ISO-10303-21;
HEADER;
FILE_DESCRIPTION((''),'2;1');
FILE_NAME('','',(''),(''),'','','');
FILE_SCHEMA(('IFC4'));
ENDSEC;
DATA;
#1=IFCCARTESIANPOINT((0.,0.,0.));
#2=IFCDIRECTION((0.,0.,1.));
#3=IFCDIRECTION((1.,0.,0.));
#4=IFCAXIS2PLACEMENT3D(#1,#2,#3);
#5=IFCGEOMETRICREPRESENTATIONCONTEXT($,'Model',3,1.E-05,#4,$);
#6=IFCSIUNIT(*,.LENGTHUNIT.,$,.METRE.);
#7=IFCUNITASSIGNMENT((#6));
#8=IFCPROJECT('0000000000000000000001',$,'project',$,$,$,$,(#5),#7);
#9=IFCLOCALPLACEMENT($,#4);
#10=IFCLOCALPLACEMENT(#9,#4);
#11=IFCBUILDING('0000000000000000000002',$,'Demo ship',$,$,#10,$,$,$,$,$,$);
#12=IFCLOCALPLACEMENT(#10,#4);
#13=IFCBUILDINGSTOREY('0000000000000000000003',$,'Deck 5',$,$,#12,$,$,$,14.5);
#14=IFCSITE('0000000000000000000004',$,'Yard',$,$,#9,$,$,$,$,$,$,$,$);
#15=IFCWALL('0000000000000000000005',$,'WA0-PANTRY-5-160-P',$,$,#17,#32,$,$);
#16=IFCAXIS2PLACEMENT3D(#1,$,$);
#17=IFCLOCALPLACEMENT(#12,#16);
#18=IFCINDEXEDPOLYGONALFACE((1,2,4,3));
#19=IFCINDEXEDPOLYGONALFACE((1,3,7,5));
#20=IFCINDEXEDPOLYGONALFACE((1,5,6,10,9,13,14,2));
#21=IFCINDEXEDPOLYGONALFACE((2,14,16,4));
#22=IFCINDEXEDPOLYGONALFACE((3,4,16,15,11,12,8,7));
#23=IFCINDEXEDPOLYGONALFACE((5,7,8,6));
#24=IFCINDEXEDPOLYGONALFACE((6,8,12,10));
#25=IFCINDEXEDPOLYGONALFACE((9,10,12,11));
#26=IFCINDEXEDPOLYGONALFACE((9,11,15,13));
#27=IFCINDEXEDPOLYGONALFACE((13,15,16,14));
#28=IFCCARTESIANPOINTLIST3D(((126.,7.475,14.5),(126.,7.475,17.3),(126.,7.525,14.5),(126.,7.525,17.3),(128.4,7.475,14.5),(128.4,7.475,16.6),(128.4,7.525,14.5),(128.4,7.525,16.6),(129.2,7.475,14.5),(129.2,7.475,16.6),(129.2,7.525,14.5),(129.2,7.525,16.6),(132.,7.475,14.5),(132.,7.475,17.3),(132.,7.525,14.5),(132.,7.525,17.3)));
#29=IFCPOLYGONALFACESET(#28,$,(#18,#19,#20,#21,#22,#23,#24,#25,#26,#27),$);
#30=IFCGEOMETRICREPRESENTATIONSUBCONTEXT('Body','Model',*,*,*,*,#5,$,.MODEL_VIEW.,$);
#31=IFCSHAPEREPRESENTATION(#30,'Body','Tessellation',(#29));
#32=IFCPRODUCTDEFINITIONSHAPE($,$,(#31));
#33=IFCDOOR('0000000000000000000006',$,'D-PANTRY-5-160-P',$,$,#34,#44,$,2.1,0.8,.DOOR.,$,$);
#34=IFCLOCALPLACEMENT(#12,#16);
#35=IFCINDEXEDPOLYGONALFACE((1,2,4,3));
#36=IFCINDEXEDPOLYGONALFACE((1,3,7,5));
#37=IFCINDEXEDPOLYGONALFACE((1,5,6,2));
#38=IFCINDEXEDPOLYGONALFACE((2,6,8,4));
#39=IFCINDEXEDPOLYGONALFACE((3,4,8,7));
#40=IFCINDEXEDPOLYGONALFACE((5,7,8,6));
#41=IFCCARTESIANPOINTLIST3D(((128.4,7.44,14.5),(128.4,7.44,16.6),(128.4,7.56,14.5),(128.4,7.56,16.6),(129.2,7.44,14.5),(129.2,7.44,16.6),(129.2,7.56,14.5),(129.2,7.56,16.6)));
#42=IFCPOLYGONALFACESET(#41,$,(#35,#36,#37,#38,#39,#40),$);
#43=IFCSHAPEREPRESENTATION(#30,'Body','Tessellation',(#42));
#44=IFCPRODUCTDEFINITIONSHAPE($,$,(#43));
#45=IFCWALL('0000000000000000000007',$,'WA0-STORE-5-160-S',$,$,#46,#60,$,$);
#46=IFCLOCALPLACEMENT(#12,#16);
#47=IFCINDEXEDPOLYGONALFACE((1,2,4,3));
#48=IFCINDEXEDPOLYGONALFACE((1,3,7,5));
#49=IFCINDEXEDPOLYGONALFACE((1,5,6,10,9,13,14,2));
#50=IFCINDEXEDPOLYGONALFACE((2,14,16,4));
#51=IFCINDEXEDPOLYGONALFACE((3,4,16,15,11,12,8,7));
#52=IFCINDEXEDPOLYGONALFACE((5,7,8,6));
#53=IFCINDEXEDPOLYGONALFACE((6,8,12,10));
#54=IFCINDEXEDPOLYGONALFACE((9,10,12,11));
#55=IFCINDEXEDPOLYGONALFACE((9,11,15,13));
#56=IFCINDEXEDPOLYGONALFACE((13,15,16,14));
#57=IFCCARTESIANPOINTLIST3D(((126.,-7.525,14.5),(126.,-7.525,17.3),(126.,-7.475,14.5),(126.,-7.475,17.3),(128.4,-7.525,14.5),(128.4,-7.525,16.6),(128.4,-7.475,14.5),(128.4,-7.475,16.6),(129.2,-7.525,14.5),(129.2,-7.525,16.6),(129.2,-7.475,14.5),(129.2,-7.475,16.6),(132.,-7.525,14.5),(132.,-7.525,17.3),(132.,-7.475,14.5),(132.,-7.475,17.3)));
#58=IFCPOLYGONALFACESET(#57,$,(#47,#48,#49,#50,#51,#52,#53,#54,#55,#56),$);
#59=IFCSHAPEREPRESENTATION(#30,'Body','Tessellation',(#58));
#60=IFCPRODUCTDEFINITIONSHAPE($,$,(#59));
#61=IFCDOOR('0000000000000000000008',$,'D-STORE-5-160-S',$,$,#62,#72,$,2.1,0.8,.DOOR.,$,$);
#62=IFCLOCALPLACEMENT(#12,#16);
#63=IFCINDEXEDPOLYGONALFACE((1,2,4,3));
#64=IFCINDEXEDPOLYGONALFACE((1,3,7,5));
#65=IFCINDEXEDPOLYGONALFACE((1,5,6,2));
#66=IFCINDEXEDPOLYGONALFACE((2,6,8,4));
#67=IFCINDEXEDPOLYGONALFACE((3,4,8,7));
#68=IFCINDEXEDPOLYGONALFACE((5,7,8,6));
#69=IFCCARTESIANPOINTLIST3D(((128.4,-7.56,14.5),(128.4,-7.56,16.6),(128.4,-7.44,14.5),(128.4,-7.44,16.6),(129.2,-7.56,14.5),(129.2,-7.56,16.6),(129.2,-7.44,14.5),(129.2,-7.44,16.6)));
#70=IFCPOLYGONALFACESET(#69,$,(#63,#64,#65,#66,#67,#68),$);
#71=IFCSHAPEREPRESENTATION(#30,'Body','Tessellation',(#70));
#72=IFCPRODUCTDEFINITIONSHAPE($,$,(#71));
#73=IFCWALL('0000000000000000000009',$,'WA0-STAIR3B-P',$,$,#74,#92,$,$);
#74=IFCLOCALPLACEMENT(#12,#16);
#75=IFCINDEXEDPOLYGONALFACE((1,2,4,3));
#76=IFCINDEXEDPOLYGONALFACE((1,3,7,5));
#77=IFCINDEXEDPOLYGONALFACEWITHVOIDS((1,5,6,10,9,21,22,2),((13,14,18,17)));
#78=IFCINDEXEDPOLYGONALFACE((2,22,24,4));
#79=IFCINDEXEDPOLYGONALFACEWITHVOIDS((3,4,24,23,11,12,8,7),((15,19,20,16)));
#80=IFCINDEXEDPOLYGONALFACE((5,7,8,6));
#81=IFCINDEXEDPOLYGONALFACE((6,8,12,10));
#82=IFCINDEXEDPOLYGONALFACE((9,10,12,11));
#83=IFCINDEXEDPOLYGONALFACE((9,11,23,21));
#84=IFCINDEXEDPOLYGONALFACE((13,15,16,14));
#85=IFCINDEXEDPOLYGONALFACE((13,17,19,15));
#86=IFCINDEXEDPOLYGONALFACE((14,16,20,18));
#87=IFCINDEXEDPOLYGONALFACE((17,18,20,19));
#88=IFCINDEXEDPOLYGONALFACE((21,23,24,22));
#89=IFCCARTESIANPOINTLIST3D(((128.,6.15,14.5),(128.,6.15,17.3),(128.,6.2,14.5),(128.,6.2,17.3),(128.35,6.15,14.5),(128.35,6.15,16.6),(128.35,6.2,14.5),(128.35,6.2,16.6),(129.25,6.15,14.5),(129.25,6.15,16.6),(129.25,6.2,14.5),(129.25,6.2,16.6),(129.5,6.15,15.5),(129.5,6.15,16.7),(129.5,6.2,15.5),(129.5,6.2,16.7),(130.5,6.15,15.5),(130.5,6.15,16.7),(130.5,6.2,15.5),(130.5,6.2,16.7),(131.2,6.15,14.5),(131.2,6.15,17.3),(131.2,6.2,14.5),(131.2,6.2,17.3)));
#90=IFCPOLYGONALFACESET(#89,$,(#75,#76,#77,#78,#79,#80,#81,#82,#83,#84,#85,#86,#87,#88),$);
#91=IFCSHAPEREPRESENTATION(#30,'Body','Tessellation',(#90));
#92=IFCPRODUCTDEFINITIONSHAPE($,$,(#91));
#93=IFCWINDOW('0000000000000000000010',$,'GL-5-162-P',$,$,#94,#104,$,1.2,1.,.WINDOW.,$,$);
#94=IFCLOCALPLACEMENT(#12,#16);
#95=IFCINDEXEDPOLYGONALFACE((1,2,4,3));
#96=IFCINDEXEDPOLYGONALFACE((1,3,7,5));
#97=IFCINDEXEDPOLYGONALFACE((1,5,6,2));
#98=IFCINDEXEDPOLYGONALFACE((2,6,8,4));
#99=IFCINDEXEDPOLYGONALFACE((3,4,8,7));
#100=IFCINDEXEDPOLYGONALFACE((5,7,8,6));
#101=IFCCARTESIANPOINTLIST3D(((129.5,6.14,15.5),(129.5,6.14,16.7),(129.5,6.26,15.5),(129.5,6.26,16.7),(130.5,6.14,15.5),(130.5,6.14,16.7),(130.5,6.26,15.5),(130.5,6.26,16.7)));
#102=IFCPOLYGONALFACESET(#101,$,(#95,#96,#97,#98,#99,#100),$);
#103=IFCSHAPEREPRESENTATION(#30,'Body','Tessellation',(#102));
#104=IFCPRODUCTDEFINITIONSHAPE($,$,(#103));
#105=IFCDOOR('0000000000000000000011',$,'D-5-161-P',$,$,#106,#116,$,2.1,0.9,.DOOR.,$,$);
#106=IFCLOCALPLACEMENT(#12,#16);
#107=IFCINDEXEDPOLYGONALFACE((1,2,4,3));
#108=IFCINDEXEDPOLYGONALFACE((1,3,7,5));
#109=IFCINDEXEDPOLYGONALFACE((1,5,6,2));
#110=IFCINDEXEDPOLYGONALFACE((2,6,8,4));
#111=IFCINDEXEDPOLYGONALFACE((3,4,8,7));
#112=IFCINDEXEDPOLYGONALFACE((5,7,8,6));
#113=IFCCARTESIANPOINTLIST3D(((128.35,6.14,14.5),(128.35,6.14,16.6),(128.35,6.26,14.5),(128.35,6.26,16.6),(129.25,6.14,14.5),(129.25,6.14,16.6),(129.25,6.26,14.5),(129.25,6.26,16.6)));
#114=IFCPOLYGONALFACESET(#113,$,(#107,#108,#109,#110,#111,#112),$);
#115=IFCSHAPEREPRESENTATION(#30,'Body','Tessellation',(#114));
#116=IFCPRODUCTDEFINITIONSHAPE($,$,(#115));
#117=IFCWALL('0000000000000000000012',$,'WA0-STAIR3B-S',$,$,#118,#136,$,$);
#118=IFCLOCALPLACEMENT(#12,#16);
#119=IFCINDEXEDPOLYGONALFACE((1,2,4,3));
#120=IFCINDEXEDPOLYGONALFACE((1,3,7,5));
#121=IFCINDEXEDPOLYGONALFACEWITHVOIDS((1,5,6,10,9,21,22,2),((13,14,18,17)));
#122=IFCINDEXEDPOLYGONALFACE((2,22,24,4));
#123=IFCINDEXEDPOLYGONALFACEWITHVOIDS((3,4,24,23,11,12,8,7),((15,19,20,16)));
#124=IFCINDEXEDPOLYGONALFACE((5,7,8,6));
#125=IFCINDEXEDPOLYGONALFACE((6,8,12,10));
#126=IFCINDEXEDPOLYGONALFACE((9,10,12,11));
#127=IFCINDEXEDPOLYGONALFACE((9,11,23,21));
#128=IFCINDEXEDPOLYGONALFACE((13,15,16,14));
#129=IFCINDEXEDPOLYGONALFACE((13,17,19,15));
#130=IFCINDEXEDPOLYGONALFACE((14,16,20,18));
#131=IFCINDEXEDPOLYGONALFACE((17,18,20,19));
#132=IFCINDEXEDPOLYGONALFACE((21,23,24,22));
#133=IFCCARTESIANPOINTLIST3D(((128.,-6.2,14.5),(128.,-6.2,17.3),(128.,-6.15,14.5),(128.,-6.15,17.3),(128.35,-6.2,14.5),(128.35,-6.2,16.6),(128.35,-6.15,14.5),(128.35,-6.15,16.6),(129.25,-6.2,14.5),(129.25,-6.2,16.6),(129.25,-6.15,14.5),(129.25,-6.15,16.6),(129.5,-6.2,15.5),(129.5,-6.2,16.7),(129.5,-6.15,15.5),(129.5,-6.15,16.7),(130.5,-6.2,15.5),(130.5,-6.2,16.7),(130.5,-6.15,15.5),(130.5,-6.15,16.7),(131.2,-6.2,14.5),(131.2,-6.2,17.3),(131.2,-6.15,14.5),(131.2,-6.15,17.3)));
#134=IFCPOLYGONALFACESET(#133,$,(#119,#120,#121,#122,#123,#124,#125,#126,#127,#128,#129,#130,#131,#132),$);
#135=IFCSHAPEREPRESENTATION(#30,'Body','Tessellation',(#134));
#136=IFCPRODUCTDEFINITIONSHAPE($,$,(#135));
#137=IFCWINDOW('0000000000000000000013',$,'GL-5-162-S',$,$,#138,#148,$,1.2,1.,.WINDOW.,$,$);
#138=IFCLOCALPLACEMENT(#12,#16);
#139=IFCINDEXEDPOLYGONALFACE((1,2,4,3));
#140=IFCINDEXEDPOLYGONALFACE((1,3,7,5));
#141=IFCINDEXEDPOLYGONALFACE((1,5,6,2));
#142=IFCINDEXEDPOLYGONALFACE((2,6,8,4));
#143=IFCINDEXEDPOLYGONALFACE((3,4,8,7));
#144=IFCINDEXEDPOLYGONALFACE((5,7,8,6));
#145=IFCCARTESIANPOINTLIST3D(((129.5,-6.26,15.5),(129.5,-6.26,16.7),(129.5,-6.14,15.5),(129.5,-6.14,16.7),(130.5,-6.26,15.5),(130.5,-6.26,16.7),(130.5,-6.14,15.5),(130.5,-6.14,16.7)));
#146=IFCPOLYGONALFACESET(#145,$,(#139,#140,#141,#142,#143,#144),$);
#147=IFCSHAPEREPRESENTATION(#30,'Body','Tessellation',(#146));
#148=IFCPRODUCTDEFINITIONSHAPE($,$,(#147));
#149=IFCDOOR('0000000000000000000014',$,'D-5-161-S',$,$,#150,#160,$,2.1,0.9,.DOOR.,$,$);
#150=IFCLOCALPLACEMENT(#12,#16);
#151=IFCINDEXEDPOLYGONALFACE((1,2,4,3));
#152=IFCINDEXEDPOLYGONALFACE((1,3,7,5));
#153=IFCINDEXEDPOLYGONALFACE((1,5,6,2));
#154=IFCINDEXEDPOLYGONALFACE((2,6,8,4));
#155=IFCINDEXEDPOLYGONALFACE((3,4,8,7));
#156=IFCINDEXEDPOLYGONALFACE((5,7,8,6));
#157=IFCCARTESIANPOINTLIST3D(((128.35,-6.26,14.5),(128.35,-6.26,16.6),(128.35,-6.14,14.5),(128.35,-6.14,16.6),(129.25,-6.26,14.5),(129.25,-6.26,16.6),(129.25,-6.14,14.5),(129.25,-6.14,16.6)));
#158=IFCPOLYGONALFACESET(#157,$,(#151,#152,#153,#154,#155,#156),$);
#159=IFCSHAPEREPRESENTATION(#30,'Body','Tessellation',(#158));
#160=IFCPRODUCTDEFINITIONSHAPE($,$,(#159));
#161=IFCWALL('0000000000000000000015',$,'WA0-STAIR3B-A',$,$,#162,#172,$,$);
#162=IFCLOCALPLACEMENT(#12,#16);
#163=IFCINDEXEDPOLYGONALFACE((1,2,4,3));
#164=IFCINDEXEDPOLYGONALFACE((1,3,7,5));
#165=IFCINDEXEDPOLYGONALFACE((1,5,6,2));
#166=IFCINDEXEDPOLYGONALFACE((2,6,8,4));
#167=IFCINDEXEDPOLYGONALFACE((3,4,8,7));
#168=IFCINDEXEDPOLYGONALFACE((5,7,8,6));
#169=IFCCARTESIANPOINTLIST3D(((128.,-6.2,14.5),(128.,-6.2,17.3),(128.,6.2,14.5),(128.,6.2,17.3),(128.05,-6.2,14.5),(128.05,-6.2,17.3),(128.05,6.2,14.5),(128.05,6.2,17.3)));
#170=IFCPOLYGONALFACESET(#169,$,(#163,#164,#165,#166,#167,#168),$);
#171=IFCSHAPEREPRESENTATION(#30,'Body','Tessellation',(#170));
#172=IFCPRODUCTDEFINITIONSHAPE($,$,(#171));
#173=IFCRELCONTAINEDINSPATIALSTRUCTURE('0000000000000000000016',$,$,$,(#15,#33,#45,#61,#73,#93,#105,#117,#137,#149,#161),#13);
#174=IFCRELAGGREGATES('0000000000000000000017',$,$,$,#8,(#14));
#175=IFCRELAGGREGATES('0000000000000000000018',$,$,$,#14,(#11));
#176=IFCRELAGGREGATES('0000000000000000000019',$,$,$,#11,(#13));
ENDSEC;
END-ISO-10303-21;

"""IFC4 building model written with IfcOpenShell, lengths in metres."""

from ifc_helpers import new_model, si_unit, frame, frame_2d, origin, origin_with_axes, place, context, subcontext, project, spatial, rectangle, extrude, element, fill, save


model = new_model("IFC4")

# Units and contexts
model_context = context("Model", 3, precision=1e-05, world=origin_with_axes())
body_context = subcontext(model_context, "Body", "Model", "MODEL_VIEW")
ifc_project = project(units=[si_unit("LENGTHUNIT", "METRE")], contexts=[model_context])

# Site, building, storey
site_placement = place(None, origin_with_axes())
site = spatial("IfcSite", under=ifc_project, at=site_placement, Name="Yard")
building_placement = place(site_placement, origin_with_axes())
building = spatial("IfcBuilding", under=site, at=building_placement, Name="Demo ship")
storey_placement = place(building_placement, origin_with_axes())
storey = spatial("IfcBuildingStorey", under=building, at=storey_placement, Name="Deck 5", Elevation=14.5)

# Walls, openings, doors
wall_1_placement = place(storey_placement, frame((126.0, 7.475, 14.5), z_axis=(0.0, 0.0, 1.0), x_axis=(1.0, 0.0, 0.0)))
wall_1 = element("IfcWall", 1, at=wall_1_placement, inside=storey, Name="WA0-PANTRY-5-160-P", context=body_context, shape_type="SweptSolid", body=[
    extrude(rectangle(XDim=6.0, YDim=0.05, at=frame_2d((3.0, 0.025))), origin(), (0.0, 0.0, 1.0), 2.8),
])
opening_1_placement = place(None, frame((128.4, 7.44, 14.5), z_axis=(0.0, 0.0, 1.0), x_axis=(1.0, 0.0, 0.0)))
opening_1 = element("IfcOpeningElement", 2, at=opening_1_placement, cuts=wall_1, context=body_context, shape_type="SweptSolid", body=[
    extrude(rectangle(XDim=0.8, YDim=0.12, at=frame_2d((0.4, 0.06))), origin(), (0.0, 0.0, 1.0), 2.1),
])
door_1_placement = place(storey_placement, frame((128.4, 7.44, 14.5), z_axis=(0.0, 0.0, 1.0), x_axis=(1.0, 0.0, 0.0)))
door_1 = element("IfcDoor", 3, at=door_1_placement, inside=storey, Name="D-PANTRY-5-160-P", OverallHeight=2.1, OverallWidth=0.8, PredefinedType="DOOR", context=body_context, shape_type="SweptSolid", body=[
    extrude(rectangle(XDim=0.8, YDim=0.12, at=frame_2d((0.4, 0.06))), origin(), (0.0, 0.0, 1.0), 2.1),
])
fill(opening_1, door_1)
wall_2_placement = place(storey_placement, frame((126.0, -7.525, 14.5), z_axis=(0.0, 0.0, 1.0), x_axis=(1.0, 0.0, 0.0)))
wall_2 = element("IfcWall", 4, at=wall_2_placement, inside=storey, Name="WA0-STORE-5-160-S", context=body_context, shape_type="SweptSolid", body=[
    extrude(rectangle(XDim=6.0, YDim=0.05, at=frame_2d((3.0, 0.025))), origin(), (0.0, 0.0, 1.0), 2.8),
])
opening_2_placement = place(None, frame((128.4, -7.56, 14.5), z_axis=(0.0, 0.0, 1.0), x_axis=(1.0, 0.0, 0.0)))
opening_2 = element("IfcOpeningElement", 5, at=opening_2_placement, cuts=wall_2, context=body_context, shape_type="SweptSolid", body=[
    extrude(rectangle(XDim=0.8, YDim=0.12, at=frame_2d((0.4, 0.06))), origin(), (0.0, 0.0, 1.0), 2.1),
])
door_2_placement = place(storey_placement, frame((128.4, -7.56, 14.5), z_axis=(0.0, 0.0, 1.0), x_axis=(1.0, 0.0, 0.0)))
door_2 = element("IfcDoor", 6, at=door_2_placement, inside=storey, Name="D-STORE-5-160-S", OverallHeight=2.1, OverallWidth=0.8, PredefinedType="DOOR", context=body_context, shape_type="SweptSolid", body=[
    extrude(rectangle(XDim=0.8, YDim=0.12, at=frame_2d((0.4, 0.06))), origin(), (0.0, 0.0, 1.0), 2.1),
])
fill(opening_2, door_2)

# Walls, openings, windows, doors
wall_3_placement = place(storey_placement, frame((128.0, 6.15, 14.5), z_axis=(0.0, 0.0, 1.0), x_axis=(1.0, 0.0, 0.0)))
wall_3 = element("IfcWall", 7, at=wall_3_placement, inside=storey, Name="WA0-STAIR3B-P", context=body_context, shape_type="SweptSolid", body=[
    extrude(rectangle(XDim=3.2, YDim=0.05, at=frame_2d((1.6, 0.025))), origin(), (0.0, 0.0, 1.0), 2.8),
])
opening_3_placement = place(None, frame((129.5, 6.14, 15.5), z_axis=(0.0, 0.0, 1.0), x_axis=(1.0, 0.0, 0.0)))
opening_3 = element("IfcOpeningElement", 8, at=opening_3_placement, cuts=wall_3, context=body_context, shape_type="SweptSolid", body=[
    extrude(rectangle(XDim=1.0, YDim=0.12, at=frame_2d((0.5, 0.06))), origin(), (0.0, 0.0, 1.0), 1.2),
])
opening_4_placement = place(None, frame((128.35, 6.14, 14.5), z_axis=(0.0, 0.0, 1.0), x_axis=(1.0, 0.0, 0.0)))
opening_4 = element("IfcOpeningElement", 9, at=opening_4_placement, cuts=wall_3, context=body_context, shape_type="SweptSolid", body=[
    extrude(rectangle(XDim=0.9, YDim=0.12, at=frame_2d((0.45, 0.06))), origin(), (0.0, 0.0, 1.0), 2.1),
])
window_1_placement = place(storey_placement, frame((129.5, 6.14, 15.5), z_axis=(0.0, 0.0, 1.0), x_axis=(1.0, 0.0, 0.0)))
window_1 = element("IfcWindow", 10, at=window_1_placement, inside=storey, Name="GL-5-162-P", OverallHeight=1.2, OverallWidth=1.0, PredefinedType="WINDOW", context=body_context, shape_type="SweptSolid", body=[
    extrude(rectangle(XDim=1.0, YDim=0.12, at=frame_2d((0.5, 0.06))), origin(), (0.0, 0.0, 1.0), 1.2),
])
fill(opening_3, window_1)
door_3_placement = place(storey_placement, frame((128.35, 6.14, 14.5), z_axis=(0.0, 0.0, 1.0), x_axis=(1.0, 0.0, 0.0)))
door_3 = element("IfcDoor", 11, at=door_3_placement, inside=storey, Name="D-5-161-P", OverallHeight=2.1, OverallWidth=0.9, PredefinedType="DOOR", context=body_context, shape_type="SweptSolid", body=[
    extrude(rectangle(XDim=0.9, YDim=0.12, at=frame_2d((0.45, 0.06))), origin(), (0.0, 0.0, 1.0), 2.1),
])
fill(opening_4, door_3)
wall_4_placement = place(storey_placement, frame((128.0, -6.2, 14.5), z_axis=(0.0, 0.0, 1.0), x_axis=(1.0, 0.0, 0.0)))
wall_4 = element("IfcWall", 12, at=wall_4_placement, inside=storey, Name="WA0-STAIR3B-S", context=body_context, shape_type="SweptSolid", body=[
    extrude(rectangle(XDim=3.2, YDim=0.05, at=frame_2d((1.6, 0.025))), origin(), (0.0, 0.0, 1.0), 2.8),
])
opening_5_placement = place(None, frame((129.5, -6.26, 15.5), z_axis=(0.0, 0.0, 1.0), x_axis=(1.0, 0.0, 0.0)))
opening_5 = element("IfcOpeningElement", 13, at=opening_5_placement, cuts=wall_4, context=body_context, shape_type="SweptSolid", body=[
    extrude(rectangle(XDim=1.0, YDim=0.12, at=frame_2d((0.5, 0.06))), origin(), (0.0, 0.0, 1.0), 1.2),
])
opening_6_placement = place(None, frame((128.35, -6.26, 14.5), z_axis=(0.0, 0.0, 1.0), x_axis=(1.0, 0.0, 0.0)))
opening_6 = element("IfcOpeningElement", 14, at=opening_6_placement, cuts=wall_4, context=body_context, shape_type="SweptSolid", body=[
    extrude(rectangle(XDim=0.9, YDim=0.12, at=frame_2d((0.45, 0.06))), origin(), (0.0, 0.0, 1.0), 2.1),
])
window_2_placement = place(storey_placement, frame((129.5, -6.26, 15.5), z_axis=(0.0, 0.0, 1.0), x_axis=(1.0, 0.0, 0.0)))
window_2 = element("IfcWindow", 15, at=window_2_placement, inside=storey, Name="GL-5-162-S", OverallHeight=1.2, OverallWidth=1.0, PredefinedType="WINDOW", context=body_context, shape_type="SweptSolid", body=[
    extrude(rectangle(XDim=1.0, YDim=0.12, at=frame_2d((0.5, 0.06))), origin(), (0.0, 0.0, 1.0), 1.2),
])
fill(opening_5, window_2)
door_4_placement = place(storey_placement, frame((128.35, -6.26, 14.5), z_axis=(0.0, 0.0, 1.0), x_axis=(1.0, 0.0, 0.0)))
door_4 = element("IfcDoor", 16, at=door_4_placement, inside=storey, Name="D-5-161-S", OverallHeight=2.1, OverallWidth=0.9, PredefinedType="DOOR", context=body_context, shape_type="SweptSolid", body=[
    extrude(rectangle(XDim=0.9, YDim=0.12, at=frame_2d((0.45, 0.06))), origin(), (0.0, 0.0, 1.0), 2.1),
])
fill(opening_6, door_4)

# Wall
wall_5_placement = place(storey_placement, frame((128.0, -6.2, 14.5), z_axis=(0.0, 0.0, 1.0), x_axis=(1.0, 0.0, 0.0)))
element("IfcWall", 17, at=wall_5_placement, inside=storey, Name="WA0-STAIR3B-A", context=body_context, shape_type="SweptSolid", body=[
    extrude(rectangle(XDim=0.05, YDim=12.4, at=frame_2d((0.025, 6.2))), origin(), (0.0, 0.0, 1.0), 2.8),
])

save(model, "model.ifc")
